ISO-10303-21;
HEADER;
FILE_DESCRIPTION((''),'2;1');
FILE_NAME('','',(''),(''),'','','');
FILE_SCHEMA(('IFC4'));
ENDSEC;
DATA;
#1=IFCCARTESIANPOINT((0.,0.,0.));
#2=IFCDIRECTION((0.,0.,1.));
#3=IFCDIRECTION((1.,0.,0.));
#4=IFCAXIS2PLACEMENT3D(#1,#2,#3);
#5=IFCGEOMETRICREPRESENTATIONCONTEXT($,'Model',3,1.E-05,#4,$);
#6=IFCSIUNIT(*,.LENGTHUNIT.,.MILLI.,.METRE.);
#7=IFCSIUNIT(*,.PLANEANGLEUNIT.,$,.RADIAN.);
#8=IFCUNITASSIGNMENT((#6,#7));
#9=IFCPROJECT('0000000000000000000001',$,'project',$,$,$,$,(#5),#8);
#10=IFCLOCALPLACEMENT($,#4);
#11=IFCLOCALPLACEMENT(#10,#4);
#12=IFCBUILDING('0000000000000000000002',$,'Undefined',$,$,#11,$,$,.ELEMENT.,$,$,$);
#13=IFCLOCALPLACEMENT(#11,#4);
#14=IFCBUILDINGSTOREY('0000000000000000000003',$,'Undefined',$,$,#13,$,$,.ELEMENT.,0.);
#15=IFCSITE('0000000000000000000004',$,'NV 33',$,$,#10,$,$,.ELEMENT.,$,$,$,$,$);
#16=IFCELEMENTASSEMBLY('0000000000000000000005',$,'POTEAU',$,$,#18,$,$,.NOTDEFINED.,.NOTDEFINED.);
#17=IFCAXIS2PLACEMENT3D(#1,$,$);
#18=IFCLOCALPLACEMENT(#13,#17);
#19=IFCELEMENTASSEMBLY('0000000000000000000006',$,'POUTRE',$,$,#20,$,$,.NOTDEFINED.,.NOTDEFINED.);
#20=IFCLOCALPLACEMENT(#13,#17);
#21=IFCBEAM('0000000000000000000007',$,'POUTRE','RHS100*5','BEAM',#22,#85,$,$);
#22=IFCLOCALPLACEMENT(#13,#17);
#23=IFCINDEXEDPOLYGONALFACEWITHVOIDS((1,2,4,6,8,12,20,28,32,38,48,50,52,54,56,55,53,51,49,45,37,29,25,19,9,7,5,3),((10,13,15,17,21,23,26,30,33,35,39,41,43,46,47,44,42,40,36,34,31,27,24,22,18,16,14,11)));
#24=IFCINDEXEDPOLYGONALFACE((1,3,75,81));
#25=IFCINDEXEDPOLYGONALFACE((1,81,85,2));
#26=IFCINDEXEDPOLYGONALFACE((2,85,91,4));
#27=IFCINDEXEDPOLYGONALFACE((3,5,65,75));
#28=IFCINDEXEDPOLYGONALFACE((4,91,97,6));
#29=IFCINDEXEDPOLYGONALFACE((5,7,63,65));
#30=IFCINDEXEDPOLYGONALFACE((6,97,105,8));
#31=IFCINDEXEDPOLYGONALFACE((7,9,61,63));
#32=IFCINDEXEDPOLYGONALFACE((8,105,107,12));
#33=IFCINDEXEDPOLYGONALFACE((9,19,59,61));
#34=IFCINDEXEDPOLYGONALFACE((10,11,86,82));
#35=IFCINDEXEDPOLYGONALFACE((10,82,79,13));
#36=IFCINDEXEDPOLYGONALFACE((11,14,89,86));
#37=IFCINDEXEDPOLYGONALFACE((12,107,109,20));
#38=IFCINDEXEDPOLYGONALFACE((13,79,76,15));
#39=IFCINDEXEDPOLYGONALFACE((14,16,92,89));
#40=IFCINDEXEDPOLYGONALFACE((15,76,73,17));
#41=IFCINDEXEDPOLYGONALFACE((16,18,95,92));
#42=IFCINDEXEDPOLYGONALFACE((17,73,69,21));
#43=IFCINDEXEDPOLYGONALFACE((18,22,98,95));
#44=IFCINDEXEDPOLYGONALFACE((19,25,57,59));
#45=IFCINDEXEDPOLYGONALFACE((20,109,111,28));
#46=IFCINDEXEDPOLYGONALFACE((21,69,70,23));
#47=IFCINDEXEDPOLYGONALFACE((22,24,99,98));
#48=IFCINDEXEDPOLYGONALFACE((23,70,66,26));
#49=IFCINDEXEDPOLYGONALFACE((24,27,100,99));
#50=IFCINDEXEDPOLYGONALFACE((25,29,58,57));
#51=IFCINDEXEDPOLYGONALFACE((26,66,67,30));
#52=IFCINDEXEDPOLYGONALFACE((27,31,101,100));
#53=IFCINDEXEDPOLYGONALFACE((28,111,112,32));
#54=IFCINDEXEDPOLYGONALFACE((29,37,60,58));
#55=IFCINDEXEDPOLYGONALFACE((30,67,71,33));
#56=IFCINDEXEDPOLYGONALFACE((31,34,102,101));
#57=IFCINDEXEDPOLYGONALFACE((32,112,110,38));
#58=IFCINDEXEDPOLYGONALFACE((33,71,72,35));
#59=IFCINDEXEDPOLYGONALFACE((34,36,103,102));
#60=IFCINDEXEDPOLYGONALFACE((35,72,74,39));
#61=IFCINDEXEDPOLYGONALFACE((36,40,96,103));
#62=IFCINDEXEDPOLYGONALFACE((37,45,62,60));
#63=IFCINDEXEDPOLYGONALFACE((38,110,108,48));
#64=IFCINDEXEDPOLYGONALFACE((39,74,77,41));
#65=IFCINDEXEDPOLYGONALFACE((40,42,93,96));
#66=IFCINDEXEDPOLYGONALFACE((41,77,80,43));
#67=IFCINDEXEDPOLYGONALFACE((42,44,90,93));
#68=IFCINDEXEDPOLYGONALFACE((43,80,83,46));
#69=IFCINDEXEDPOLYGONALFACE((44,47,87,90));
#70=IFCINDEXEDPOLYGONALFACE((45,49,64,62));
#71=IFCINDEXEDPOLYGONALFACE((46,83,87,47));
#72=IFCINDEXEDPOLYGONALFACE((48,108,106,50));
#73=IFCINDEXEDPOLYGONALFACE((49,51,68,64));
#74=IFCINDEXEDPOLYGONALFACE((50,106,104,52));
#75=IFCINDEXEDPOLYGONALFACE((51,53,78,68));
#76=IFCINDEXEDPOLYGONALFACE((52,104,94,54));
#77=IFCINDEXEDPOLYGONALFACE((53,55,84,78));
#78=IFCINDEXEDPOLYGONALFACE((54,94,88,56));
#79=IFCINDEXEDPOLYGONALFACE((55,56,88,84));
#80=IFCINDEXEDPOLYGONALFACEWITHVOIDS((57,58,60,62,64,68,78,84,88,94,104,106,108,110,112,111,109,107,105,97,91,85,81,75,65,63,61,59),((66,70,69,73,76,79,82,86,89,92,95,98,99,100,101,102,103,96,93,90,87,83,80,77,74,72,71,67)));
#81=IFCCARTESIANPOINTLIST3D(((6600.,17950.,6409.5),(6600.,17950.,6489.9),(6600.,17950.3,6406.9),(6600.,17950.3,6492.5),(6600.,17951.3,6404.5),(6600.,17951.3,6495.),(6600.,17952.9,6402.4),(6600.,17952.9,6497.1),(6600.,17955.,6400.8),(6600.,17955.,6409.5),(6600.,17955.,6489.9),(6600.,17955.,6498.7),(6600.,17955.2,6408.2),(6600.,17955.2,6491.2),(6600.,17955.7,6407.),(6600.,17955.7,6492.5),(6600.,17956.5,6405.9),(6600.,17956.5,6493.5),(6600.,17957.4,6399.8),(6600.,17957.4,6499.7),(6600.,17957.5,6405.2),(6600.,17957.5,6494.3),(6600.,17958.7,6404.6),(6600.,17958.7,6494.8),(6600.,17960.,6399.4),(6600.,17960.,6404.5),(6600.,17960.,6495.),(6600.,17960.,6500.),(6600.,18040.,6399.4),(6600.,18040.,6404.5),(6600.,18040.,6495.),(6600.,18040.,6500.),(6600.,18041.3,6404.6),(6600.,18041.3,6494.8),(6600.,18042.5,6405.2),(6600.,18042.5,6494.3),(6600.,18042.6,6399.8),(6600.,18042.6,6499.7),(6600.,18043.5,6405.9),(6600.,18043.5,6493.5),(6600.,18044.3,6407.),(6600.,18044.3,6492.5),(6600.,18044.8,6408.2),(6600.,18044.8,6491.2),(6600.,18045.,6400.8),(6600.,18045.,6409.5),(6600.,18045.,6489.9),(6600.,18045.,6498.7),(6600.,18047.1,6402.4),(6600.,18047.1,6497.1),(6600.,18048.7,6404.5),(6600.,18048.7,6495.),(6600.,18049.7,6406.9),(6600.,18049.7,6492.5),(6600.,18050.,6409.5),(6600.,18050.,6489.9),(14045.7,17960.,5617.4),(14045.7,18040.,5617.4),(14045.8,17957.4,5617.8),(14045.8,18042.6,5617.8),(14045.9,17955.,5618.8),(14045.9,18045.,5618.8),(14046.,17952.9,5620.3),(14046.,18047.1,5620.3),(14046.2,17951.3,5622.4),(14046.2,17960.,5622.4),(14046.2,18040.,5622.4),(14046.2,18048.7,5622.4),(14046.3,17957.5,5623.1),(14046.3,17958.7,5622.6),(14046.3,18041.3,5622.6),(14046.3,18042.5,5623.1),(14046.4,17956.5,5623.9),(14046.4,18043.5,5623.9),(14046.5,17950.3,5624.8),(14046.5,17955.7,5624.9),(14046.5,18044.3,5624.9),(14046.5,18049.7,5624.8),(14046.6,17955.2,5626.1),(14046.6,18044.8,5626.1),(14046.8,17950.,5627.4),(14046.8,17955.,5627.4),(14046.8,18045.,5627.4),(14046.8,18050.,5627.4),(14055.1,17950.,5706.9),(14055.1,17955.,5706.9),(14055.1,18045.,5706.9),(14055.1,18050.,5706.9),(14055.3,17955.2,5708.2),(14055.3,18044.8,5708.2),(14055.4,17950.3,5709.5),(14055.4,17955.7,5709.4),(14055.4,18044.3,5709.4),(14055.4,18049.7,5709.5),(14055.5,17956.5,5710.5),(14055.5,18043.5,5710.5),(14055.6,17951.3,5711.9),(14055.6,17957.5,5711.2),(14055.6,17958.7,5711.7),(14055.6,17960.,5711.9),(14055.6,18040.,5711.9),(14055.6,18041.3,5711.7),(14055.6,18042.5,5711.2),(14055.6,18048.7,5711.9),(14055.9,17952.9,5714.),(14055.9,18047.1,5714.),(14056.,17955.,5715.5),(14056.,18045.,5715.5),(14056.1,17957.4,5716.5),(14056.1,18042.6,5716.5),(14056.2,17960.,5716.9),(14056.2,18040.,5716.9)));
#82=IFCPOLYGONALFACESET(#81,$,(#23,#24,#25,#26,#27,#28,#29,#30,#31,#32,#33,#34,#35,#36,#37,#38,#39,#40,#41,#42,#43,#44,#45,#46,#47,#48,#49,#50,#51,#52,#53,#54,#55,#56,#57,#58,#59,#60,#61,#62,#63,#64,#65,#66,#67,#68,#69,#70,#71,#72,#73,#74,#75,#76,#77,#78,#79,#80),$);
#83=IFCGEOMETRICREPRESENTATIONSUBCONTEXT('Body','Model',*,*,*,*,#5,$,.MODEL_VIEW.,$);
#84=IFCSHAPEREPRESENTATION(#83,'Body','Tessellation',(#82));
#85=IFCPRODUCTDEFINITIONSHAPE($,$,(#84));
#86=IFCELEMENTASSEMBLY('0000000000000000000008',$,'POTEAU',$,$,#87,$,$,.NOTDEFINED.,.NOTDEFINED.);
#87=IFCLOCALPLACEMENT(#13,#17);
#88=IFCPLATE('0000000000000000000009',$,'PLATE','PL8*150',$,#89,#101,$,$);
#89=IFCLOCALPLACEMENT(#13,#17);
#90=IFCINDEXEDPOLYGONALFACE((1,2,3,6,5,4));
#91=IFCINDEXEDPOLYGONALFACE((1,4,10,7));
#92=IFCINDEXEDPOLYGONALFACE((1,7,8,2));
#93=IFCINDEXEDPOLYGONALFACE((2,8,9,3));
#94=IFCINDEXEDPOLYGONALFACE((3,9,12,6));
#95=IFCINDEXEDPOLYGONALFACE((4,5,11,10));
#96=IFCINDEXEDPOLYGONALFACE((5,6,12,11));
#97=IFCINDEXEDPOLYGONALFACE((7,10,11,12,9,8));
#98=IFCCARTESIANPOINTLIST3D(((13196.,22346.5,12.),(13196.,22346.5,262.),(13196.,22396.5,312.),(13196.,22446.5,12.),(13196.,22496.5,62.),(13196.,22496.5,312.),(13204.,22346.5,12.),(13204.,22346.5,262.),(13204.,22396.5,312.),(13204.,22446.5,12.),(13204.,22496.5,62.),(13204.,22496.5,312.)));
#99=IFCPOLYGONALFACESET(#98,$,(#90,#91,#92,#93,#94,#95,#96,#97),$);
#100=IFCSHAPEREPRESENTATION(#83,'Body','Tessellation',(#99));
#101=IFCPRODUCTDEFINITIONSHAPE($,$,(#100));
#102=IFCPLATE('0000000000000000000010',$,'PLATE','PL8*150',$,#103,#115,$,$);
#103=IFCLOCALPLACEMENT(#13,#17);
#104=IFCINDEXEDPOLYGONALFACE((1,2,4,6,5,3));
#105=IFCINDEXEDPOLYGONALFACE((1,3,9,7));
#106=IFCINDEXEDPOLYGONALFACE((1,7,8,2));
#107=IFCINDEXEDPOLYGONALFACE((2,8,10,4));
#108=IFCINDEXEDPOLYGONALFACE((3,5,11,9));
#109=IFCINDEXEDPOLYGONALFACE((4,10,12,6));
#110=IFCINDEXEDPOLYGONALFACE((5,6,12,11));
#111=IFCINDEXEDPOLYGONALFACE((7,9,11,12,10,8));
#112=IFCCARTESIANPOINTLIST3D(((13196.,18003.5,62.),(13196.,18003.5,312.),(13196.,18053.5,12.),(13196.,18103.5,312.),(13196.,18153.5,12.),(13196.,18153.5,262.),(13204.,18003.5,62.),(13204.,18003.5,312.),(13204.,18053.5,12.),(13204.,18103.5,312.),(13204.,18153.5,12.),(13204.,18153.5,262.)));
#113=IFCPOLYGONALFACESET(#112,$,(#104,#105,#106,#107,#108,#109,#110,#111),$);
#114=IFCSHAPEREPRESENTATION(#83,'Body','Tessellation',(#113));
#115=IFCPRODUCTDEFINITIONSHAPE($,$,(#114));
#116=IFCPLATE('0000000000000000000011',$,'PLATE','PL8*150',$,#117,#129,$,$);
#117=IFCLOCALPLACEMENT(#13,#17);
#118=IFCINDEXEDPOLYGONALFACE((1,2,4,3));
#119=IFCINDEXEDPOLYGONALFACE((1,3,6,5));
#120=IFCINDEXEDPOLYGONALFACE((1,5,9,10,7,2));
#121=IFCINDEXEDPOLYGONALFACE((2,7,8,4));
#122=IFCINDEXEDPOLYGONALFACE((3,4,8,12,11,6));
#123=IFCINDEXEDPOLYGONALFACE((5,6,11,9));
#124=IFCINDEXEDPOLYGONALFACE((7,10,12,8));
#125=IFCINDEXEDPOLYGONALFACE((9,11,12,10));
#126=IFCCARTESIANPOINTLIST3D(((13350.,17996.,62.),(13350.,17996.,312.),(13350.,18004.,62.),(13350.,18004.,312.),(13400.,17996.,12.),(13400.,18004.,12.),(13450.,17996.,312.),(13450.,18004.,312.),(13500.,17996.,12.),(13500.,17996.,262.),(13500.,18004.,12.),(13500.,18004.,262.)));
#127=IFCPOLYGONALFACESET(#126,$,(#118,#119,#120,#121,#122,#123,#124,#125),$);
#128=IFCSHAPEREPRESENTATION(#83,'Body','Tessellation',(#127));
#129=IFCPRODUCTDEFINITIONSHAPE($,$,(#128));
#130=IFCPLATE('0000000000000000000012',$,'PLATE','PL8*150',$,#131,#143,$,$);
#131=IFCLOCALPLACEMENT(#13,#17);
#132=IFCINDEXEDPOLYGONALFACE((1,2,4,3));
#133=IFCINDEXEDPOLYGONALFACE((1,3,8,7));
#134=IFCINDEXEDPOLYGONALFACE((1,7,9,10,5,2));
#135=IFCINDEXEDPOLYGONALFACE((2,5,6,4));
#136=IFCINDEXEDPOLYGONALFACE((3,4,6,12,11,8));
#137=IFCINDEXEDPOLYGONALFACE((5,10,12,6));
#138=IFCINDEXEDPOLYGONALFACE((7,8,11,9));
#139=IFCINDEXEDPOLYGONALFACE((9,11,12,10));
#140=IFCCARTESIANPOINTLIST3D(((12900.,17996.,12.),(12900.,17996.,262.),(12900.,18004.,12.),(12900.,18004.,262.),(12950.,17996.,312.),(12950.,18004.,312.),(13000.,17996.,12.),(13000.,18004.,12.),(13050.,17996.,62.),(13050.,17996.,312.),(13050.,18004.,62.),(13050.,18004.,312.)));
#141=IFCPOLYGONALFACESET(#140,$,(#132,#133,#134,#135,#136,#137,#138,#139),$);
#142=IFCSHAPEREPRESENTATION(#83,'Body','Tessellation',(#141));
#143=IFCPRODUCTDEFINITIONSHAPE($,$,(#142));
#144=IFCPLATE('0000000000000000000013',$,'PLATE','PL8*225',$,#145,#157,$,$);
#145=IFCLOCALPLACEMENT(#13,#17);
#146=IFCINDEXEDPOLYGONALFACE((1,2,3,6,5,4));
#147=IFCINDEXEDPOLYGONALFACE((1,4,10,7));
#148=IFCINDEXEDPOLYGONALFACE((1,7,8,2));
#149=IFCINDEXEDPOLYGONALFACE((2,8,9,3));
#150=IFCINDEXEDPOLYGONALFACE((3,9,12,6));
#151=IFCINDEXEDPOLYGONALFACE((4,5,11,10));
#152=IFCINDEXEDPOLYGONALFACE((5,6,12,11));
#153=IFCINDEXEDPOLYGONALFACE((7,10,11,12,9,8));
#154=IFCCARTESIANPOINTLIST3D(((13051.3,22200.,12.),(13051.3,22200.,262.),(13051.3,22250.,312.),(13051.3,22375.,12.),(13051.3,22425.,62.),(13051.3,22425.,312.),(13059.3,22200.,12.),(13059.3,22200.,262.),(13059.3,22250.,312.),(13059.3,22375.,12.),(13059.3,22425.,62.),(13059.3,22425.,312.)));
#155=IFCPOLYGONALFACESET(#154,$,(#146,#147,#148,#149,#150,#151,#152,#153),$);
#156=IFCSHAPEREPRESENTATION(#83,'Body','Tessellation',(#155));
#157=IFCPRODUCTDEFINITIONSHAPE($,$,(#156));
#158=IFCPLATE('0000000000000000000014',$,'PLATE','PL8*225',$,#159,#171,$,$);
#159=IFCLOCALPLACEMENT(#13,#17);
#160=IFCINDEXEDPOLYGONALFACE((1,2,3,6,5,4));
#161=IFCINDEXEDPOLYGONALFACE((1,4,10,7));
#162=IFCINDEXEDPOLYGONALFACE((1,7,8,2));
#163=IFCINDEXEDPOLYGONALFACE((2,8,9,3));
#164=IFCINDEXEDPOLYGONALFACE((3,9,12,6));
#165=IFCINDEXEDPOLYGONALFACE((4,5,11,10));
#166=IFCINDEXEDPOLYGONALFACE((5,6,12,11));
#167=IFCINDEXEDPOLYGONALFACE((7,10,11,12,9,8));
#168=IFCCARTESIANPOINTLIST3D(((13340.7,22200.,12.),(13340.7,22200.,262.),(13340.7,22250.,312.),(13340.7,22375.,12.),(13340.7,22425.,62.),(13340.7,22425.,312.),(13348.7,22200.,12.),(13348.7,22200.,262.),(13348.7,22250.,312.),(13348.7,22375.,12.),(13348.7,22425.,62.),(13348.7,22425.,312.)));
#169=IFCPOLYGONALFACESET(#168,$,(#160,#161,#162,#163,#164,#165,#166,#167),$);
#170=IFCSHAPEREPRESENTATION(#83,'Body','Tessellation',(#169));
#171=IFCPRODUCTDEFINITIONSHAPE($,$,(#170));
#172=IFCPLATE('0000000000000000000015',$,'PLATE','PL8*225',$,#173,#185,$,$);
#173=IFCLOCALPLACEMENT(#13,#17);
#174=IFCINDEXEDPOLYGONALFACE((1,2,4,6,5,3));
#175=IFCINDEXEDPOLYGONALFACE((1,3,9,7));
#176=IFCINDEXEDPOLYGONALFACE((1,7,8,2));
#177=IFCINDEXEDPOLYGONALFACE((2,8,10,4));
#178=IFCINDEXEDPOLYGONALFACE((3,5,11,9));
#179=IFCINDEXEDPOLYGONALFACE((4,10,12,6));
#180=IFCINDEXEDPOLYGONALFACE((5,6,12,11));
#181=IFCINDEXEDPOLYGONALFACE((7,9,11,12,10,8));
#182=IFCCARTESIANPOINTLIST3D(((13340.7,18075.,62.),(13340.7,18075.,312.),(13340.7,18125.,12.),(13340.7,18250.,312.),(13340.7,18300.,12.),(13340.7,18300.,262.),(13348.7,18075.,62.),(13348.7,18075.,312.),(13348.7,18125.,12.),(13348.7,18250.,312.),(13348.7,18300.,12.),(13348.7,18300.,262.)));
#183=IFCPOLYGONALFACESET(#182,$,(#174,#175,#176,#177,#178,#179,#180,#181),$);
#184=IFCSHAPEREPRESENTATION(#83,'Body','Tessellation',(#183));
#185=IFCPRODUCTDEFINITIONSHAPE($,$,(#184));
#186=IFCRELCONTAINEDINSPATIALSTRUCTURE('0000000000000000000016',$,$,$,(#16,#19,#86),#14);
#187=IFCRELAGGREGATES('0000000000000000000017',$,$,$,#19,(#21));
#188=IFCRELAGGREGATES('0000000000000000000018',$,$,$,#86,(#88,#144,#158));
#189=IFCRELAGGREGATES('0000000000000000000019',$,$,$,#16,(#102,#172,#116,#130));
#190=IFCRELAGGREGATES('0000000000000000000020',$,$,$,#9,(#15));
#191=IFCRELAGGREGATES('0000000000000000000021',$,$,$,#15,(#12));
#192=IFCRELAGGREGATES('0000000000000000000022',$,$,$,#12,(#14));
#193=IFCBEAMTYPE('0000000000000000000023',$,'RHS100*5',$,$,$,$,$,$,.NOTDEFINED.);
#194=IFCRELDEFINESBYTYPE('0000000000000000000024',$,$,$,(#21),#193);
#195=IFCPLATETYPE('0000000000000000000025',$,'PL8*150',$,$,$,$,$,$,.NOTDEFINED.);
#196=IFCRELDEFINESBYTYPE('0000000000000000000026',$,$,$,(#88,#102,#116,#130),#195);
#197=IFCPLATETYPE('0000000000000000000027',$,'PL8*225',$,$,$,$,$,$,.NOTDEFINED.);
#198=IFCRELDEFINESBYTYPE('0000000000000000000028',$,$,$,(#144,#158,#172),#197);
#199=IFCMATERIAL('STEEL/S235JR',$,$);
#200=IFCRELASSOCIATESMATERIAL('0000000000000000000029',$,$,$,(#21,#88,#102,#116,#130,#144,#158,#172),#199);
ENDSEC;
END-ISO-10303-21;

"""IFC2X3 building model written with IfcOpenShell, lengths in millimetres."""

from ifc_helpers import new_model, si_unit, frame, origin_with_axes, origin_2d_with_axis, place, context, subcontext, project, spatial, polyline, hollow_rectangle, outline, extrude, clip, halfspace, material, type_object, element, aggregate, save


model = new_model("IFC2X3")

# Units and contexts
model_context = context("Model", 3, precision=1e-05, world=origin_with_axes())
body_context = subcontext(model_context, "Body", "Model", "MODEL_VIEW")
ifc_project = project(units=[si_unit("LENGTHUNIT", "METRE", prefix="MILLI"), si_unit("PLANEANGLEUNIT", "RADIAN")], contexts=[model_context])

# Site, building, storey
site_placement = place(None, origin_with_axes())
site = spatial("IfcSite", under=ifc_project, at=site_placement, Name="NV 33", CompositionType="ELEMENT")
building_placement = place(site_placement, origin_with_axes())
building = spatial("IfcBuilding", under=site, at=building_placement, Name="Undefined", CompositionType="ELEMENT")
storey_placement = place(building_placement, origin_with_axes())
storey = spatial("IfcBuildingStorey", under=building, at=storey_placement, Name="Undefined", CompositionType="ELEMENT", Elevation=0.0)

# Element assembly
assembly_1_placement = place(storey_placement, origin_with_axes())
assembly_1 = element("IfcElementAssembly", 1, at=assembly_1_placement, inside=storey, Name="POTEAU", AssemblyPlace="NOTDEFINED", PredefinedType="NOTDEFINED")
ifc_material_1 = material(Name="STEEL/S235JR")

# Shared definitions
beam_type_1 = type_object("IfcBeamType", Name="RHS100*5", PredefinedType="NOTDEFINED")

# Element assembly, beam
assembly_2_placement = place(storey_placement, origin_with_axes())
assembly_2 = element("IfcElementAssembly", 2, at=assembly_2_placement, inside=storey, Name="POUTRE", AssemblyPlace="NOTDEFINED", PredefinedType="NOTDEFINED")
beam_1_placement = place(assembly_2_placement, frame((14050.9, 18000.0, 5667.2), z_axis=(-0.104455, 0.0, -0.99453), x_axis=(-0.99453, 0.0, 0.104455)))
beam_1 = element("IfcBeam", 3, at=beam_1_placement, type_object=beam_type_1, material=ifc_material_1, Name="POUTRE", Description="RHS100*5", ObjectType="BEAM", context=body_context, shape_type="Clipping", body=[
    clip(extrude(hollow_rectangle(XDim=100.0, YDim=100.0, WallThickness=5.0, InnerFilletRadius=5.0, OuterFilletRadius=10.0, at=origin_2d_with_axis()), frame((7527.2, 0.0, 0.0), z_axis=(-1.0, 0.0, 0.0), x_axis=(0.0, -1.0, 0.0)), (0.0, 0.0, 1.0), 7527.2), halfspace(frame((7497.2, 50.0, -50.0), z_axis=(0.99453, 0.0, 0.104455), x_axis=(0.0, -1.0, 0.0)), False)),
])
aggregate(assembly_2, [beam_1])

# Element assembly, plate
assembly_3_placement = place(storey_placement, origin_with_axes())
assembly_3 = element("IfcElementAssembly", 4, at=assembly_3_placement, inside=storey, Name="POTEAU", AssemblyPlace="NOTDEFINED", PredefinedType="NOTDEFINED")
plate_type_1 = type_object("IfcPlateType", Name="PL8*150", PredefinedType="NOTDEFINED")
plate_1_placement = place(assembly_3_placement, frame((13200.0, 22496.5, 12.0), z_axis=(-1.0, 0.0, 0.0), x_axis=(0.0, -1.0, 0.0)))
plate_1 = element("IfcPlate", 5, at=plate_1_placement, type_object=plate_type_1, material=ifc_material_1, Name="PLATE", Description="PL8*150", context=body_context, shape_type="SweptSolid", body=[
    extrude(outline(polyline([(0.0, 50.0), (50.0, 0.0), (150.0, 0.0), (150.0, 250.0), (100.0, 300.0), (0.0, 300.0), (0.0, 50.0)])), frame((0.0, 0.0, -4.0), z_axis=(0.0, 0.0, 1.0), x_axis=(1.0, 0.0, 0.0)), (0.0, 0.0, 1.0), 8.0),
])

# Plates
plate_2_placement = place(assembly_1_placement, frame((13200.0, 18003.5, 12.0), z_axis=(1.0, 0.0, 0.0), x_axis=(0.0, 1.0, 0.0)))
plate_2 = element("IfcPlate", 6, at=plate_2_placement, type_object=plate_type_1, material=ifc_material_1, Name="PLATE", Description="PL8*150", context=body_context, shape_type="SweptSolid", body=[
    extrude(outline(polyline([(0.0, 50.0), (50.0, 0.0), (150.0, 0.0), (150.0, 250.0), (100.0, 300.0), (0.0, 300.0), (0.0, 50.0)])), frame((0.0, 0.0, -4.0), z_axis=(0.0, 0.0, 1.0), x_axis=(1.0, 0.0, 0.0)), (0.0, 0.0, 1.0), 8.0),
])
plate_3_placement = place(assembly_1_placement, frame((13350.0, 18000.0, 12.0), z_axis=(0.0, -1.0, 0.0), x_axis=(1.0, 0.0, 0.0)))
plate_3 = element("IfcPlate", 7, at=plate_3_placement, type_object=plate_type_1, material=ifc_material_1, Name="PLATE", Description="PL8*150", context=body_context, shape_type="SweptSolid", body=[
    extrude(outline(polyline([(0.0, 50.0), (50.0, 0.0), (150.0, 0.0), (150.0, 250.0), (100.0, 300.0), (0.0, 300.0), (0.0, 50.0)])), frame((0.0, 0.0, -4.0), z_axis=(0.0, 0.0, 1.0), x_axis=(1.0, 0.0, 0.0)), (0.0, 0.0, 1.0), 8.0),
])
plate_4_placement = place(assembly_1_placement, frame((13050.0, 18000.0, 12.0), z_axis=(0.0, 1.0, 0.0), x_axis=(-1.0, 0.0, 0.0)))
plate_4 = element("IfcPlate", 8, at=plate_4_placement, type_object=plate_type_1, material=ifc_material_1, Name="PLATE", Description="PL8*150", context=body_context, shape_type="SweptSolid", body=[
    extrude(outline(polyline([(0.0, 50.0), (50.0, 0.0), (150.0, 0.0), (150.0, 250.0), (100.0, 300.0), (0.0, 300.0), (0.0, 50.0)])), frame((0.0, 0.0, -4.0), z_axis=(0.0, 0.0, 1.0), x_axis=(1.0, 0.0, 0.0)), (0.0, 0.0, 1.0), 8.0),
])
plate_type_2 = type_object("IfcPlateType", Name="PL8*225", PredefinedType="NOTDEFINED")
plate_5_placement = place(assembly_3_placement, frame((13055.3, 22425.0, 12.0), z_axis=(-1.0, 0.0, 0.0), x_axis=(0.0, -1.0, 0.0)))
plate_5 = element("IfcPlate", 9, at=plate_5_placement, type_object=plate_type_2, material=ifc_material_1, Name="PLATE", Description="PL8*225", context=body_context, shape_type="SweptSolid", body=[
    extrude(outline(polyline([(0.0, 50.0), (50.0, 0.0), (225.0, 0.0), (225.0, 250.0), (175.0, 300.0), (0.0, 300.0), (0.0, 50.0)])), frame((0.0, 0.0, -4.0), z_axis=(0.0, 0.0, 1.0), x_axis=(1.0, 0.0, 0.0)), (0.0, 0.0, 1.0), 8.0),
])
plate_6_placement = place(assembly_3_placement, frame((13344.7, 22425.0, 12.0), z_axis=(-1.0, 0.0, 0.0), x_axis=(0.0, -1.0, 0.0)))
plate_6 = element("IfcPlate", 10, at=plate_6_placement, type_object=plate_type_2, material=ifc_material_1, Name="PLATE", Description="PL8*225", context=body_context, shape_type="SweptSolid", body=[
    extrude(outline(polyline([(0.0, 50.0), (50.0, 0.0), (225.0, 0.0), (225.0, 250.0), (175.0, 300.0), (0.0, 300.0), (0.0, 50.0)])), frame((0.0, 0.0, -4.0), z_axis=(0.0, 0.0, 1.0), x_axis=(1.0, 0.0, 0.0)), (0.0, 0.0, 1.0), 8.0),
])
plate_7_placement = place(assembly_1_placement, frame((13344.7, 18075.0, 12.0), z_axis=(1.0, 0.0, 0.0), x_axis=(0.0, 1.0, 0.0)))
plate_7 = element("IfcPlate", 11, at=plate_7_placement, type_object=plate_type_2, material=ifc_material_1, Name="PLATE", Description="PL8*225", context=body_context, shape_type="SweptSolid", body=[
    extrude(outline(polyline([(0.0, 50.0), (50.0, 0.0), (225.0, 0.0), (225.0, 250.0), (175.0, 300.0), (0.0, 300.0), (0.0, 50.0)])), frame((0.0, 0.0, -4.0), z_axis=(0.0, 0.0, 1.0), x_axis=(1.0, 0.0, 0.0)), (0.0, 0.0, 1.0), 8.0),
])
aggregate(assembly_3, [plate_1, plate_5, plate_6])

aggregate(assembly_1, [plate_2, plate_7, plate_3, plate_4])

save(model, "model.ifc")
